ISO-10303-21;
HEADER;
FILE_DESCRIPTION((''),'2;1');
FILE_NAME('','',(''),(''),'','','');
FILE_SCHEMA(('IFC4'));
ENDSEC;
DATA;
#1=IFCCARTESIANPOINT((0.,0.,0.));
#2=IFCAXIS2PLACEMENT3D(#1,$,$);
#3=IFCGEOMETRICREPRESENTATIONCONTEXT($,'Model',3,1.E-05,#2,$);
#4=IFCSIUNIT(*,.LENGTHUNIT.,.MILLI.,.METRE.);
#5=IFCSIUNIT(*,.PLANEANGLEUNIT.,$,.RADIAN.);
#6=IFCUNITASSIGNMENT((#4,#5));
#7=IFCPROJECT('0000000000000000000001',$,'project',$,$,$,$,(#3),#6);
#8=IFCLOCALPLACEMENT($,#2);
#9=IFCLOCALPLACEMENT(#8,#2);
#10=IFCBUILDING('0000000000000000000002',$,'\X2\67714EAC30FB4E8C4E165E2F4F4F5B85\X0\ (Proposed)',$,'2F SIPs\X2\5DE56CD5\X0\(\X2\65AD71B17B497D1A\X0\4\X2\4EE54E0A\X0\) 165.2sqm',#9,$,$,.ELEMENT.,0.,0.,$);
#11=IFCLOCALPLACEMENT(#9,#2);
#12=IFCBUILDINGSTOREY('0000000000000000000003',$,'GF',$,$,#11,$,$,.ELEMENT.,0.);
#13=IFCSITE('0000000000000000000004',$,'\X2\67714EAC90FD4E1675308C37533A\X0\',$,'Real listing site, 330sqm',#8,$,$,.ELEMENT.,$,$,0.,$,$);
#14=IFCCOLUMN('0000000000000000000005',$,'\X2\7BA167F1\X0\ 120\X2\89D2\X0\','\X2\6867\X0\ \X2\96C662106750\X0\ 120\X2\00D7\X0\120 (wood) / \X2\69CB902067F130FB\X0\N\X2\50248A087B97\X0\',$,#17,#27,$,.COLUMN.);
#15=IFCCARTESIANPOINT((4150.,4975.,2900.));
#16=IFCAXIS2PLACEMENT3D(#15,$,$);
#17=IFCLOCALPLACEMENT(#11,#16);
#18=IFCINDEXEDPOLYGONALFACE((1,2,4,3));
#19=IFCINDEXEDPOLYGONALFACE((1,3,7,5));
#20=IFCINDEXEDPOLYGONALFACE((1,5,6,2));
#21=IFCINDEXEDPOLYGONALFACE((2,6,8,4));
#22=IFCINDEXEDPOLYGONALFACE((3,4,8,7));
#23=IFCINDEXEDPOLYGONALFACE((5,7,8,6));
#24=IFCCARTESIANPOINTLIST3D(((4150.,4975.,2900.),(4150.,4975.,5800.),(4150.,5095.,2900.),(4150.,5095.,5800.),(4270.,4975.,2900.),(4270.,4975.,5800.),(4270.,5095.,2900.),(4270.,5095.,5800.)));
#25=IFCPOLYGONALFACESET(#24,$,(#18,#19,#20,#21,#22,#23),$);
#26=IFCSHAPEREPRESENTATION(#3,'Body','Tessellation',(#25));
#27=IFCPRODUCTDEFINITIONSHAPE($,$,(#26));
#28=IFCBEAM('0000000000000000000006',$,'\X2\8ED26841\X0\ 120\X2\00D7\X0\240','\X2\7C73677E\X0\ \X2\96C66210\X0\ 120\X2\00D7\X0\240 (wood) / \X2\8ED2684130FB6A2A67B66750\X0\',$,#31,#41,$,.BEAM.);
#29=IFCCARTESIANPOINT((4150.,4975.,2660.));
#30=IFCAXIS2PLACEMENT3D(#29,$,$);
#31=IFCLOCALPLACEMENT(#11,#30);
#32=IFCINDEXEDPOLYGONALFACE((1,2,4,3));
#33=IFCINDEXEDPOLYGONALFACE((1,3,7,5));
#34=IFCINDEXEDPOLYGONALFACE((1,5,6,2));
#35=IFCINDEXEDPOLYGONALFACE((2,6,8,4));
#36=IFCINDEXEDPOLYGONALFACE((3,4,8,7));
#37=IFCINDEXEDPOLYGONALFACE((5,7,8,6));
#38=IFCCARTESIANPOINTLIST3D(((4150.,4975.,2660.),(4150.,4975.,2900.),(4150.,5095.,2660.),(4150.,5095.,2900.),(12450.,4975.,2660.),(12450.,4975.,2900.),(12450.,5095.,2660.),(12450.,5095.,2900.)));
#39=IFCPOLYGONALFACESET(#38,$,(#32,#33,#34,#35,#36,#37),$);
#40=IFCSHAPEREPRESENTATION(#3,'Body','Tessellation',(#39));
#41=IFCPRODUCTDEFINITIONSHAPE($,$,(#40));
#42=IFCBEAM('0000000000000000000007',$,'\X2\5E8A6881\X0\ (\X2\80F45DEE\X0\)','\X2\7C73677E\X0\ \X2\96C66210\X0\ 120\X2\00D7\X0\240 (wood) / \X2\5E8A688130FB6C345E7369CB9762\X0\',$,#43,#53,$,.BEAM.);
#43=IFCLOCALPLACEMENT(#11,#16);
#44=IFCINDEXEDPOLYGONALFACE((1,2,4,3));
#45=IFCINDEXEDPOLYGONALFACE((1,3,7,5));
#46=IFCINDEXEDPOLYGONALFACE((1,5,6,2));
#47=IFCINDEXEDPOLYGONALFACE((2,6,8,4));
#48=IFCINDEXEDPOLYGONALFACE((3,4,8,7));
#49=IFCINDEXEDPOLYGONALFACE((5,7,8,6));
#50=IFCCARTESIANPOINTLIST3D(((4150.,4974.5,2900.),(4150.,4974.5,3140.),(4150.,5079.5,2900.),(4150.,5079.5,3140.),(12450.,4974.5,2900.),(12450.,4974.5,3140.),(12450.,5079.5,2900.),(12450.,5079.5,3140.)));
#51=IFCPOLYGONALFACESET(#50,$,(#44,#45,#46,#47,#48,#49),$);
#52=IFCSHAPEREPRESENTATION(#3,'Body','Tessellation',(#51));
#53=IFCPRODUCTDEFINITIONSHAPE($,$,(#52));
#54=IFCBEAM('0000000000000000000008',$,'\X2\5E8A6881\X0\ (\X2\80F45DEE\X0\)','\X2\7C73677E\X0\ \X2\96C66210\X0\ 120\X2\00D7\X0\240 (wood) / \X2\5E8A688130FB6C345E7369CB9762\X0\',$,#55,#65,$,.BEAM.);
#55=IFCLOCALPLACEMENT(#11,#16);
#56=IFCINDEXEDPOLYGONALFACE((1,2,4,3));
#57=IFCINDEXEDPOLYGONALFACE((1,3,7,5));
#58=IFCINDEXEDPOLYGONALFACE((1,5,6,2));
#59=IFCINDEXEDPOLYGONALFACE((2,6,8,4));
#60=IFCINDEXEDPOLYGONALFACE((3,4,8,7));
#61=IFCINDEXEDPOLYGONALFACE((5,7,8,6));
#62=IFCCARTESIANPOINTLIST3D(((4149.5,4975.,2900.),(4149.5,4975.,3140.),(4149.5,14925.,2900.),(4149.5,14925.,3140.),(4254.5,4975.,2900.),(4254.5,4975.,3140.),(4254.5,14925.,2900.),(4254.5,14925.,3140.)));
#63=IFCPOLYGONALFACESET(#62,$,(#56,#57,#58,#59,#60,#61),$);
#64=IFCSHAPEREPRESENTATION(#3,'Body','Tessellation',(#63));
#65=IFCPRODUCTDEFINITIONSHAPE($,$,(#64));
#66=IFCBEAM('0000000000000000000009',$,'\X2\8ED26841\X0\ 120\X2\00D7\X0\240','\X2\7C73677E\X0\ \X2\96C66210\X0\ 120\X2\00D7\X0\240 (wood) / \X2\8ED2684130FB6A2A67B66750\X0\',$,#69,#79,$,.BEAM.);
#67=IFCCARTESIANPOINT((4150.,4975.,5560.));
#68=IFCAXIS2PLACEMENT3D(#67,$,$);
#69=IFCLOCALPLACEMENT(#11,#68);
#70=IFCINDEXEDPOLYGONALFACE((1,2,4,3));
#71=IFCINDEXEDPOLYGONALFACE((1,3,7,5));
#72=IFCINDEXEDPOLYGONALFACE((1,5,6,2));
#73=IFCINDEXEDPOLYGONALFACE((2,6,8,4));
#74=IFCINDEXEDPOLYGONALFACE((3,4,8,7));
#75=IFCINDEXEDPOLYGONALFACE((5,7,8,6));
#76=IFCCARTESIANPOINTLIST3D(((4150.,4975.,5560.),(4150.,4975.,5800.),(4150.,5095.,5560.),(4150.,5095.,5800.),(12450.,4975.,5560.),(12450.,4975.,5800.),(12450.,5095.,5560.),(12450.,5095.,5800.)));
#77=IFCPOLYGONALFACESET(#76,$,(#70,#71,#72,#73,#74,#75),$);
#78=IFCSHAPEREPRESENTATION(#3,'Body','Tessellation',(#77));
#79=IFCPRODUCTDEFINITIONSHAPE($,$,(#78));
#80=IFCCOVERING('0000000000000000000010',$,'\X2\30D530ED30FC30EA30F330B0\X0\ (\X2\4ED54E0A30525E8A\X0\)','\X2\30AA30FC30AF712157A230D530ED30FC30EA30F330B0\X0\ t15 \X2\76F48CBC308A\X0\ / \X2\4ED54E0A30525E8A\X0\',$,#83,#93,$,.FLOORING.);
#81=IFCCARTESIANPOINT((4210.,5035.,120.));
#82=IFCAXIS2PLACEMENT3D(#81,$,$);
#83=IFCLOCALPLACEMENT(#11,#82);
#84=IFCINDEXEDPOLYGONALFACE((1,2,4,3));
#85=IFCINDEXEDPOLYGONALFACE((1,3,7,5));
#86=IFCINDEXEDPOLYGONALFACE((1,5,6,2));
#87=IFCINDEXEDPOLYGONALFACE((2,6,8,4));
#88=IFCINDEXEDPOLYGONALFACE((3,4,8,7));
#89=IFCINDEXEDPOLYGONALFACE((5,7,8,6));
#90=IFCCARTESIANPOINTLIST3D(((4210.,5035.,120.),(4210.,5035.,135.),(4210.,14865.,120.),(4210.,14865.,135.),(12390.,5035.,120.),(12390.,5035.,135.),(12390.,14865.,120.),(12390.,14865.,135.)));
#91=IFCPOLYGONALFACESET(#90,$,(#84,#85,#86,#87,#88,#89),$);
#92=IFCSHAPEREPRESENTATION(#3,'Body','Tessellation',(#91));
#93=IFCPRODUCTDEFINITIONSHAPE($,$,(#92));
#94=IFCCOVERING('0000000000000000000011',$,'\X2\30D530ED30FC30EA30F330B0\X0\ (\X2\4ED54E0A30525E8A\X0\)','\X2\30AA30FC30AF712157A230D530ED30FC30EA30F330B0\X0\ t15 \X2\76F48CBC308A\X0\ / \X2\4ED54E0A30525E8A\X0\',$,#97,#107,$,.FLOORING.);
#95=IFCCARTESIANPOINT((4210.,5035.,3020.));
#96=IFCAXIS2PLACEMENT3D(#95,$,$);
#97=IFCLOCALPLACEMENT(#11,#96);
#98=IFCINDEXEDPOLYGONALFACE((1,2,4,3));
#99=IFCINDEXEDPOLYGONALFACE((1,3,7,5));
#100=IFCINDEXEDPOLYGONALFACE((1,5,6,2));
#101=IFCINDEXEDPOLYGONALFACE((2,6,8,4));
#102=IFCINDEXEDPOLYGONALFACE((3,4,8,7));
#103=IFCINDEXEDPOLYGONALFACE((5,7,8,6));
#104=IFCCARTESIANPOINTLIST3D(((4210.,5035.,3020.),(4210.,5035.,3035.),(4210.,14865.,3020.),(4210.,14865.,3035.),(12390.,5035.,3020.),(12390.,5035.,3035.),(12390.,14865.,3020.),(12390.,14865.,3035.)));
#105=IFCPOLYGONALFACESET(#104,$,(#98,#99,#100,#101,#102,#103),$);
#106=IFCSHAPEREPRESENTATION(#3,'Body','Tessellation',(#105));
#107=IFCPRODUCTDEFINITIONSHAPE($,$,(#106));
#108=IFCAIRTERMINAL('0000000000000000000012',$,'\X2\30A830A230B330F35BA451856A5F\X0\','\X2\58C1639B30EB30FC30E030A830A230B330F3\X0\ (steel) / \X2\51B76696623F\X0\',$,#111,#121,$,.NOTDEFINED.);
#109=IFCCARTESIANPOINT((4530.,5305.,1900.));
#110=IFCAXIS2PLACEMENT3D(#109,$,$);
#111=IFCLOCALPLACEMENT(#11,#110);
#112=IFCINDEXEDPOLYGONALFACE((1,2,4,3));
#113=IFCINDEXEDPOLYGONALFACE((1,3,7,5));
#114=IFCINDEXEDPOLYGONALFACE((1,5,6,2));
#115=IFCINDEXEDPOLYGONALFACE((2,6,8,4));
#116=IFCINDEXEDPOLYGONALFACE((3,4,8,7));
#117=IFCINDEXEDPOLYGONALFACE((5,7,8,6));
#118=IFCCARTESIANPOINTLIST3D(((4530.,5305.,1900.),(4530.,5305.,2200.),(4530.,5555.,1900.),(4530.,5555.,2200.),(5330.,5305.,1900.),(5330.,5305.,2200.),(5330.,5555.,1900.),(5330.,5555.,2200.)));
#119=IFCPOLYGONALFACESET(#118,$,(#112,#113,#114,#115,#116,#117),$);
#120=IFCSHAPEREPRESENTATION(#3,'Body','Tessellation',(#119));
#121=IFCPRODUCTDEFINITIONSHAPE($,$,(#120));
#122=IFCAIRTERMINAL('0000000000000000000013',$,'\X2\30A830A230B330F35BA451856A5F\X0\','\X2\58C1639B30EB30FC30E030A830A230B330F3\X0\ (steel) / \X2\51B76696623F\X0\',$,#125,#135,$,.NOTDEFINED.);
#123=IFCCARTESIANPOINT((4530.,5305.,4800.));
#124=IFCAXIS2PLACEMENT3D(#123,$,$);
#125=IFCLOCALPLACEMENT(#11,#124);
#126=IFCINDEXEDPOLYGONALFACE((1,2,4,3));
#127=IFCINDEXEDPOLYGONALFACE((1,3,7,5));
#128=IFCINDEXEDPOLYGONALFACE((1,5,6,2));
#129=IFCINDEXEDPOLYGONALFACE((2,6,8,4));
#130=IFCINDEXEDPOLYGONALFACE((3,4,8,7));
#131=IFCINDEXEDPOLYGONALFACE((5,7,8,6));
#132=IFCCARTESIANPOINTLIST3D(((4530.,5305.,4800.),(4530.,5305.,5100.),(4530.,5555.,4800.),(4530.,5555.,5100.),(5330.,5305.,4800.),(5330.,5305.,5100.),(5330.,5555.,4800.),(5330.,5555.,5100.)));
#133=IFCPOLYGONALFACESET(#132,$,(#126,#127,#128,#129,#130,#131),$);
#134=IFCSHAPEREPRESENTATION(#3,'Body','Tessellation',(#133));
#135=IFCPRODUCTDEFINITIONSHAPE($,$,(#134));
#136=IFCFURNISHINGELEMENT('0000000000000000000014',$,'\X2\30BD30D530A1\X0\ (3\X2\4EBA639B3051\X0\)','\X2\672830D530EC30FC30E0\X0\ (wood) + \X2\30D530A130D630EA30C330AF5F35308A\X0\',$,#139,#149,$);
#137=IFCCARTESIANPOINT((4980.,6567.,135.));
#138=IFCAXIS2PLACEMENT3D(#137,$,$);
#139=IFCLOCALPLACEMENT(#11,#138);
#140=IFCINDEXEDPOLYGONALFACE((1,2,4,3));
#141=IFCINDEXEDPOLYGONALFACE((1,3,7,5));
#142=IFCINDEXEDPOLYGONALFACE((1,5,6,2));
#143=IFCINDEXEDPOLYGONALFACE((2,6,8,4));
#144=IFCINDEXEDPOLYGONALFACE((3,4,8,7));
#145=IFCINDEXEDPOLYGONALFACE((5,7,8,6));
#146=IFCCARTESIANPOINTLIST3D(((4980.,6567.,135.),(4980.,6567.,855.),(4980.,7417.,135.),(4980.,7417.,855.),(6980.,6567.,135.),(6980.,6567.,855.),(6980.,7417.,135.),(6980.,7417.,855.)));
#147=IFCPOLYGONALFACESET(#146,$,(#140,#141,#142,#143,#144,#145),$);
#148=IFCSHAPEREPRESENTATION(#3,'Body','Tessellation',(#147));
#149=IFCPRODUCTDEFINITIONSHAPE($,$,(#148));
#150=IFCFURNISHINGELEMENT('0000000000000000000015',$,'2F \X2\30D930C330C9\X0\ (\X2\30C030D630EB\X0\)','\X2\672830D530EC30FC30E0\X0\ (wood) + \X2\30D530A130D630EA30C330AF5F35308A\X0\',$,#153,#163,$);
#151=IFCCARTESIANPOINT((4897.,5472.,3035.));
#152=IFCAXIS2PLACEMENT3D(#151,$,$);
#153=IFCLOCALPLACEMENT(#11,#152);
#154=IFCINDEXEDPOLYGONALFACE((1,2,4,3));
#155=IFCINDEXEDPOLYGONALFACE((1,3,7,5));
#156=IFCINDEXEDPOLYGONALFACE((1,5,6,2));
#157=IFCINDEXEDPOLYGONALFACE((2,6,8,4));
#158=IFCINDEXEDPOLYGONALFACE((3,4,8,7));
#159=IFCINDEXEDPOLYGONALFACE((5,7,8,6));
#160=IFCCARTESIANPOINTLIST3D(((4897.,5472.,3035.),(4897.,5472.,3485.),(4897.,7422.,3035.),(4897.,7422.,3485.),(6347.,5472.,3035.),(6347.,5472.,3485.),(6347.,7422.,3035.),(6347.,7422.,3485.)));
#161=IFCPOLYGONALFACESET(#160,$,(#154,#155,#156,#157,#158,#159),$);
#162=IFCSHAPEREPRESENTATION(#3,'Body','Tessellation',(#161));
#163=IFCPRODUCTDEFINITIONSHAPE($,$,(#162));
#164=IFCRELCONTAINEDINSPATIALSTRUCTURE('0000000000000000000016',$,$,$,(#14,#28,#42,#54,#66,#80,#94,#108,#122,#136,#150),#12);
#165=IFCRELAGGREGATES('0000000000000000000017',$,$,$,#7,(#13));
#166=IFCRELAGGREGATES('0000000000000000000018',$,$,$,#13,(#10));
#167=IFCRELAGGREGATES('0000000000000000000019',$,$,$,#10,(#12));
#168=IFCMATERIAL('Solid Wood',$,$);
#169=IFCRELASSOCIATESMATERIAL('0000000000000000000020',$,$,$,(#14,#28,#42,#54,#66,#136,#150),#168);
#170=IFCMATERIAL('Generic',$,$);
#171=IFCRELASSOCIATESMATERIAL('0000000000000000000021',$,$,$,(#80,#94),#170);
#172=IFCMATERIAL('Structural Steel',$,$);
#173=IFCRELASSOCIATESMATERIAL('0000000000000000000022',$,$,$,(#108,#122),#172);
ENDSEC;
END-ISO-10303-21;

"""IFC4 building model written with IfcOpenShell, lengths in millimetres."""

from ifc_helpers import new_model, si_unit, frame, frame_2d, origin, place, context, project, spatial, rectangle, extrude, material, element, save


model = new_model("IFC4")

# Units and contexts
model_context = context("Model", 3, precision=1e-05, world=origin())
ifc_project = project(units=[si_unit("LENGTHUNIT", "METRE", prefix="MILLI"), si_unit("PLANEANGLEUNIT", "RADIAN")], contexts=[model_context])

# Site, building, storey
site_placement = place(None, origin())
site = spatial("IfcSite", under=ifc_project, at=site_placement, Name="東京都世田谷区", ObjectType="Real listing site, 330sqm", CompositionType="ELEMENT", RefElevation=0.0)
building_placement = place(site_placement, origin())
building = spatial("IfcBuilding", under=site, at=building_placement, Name="東京・二世帯住宅 (Proposed)", ObjectType="2F SIPs工法(断熱等級4以上) 165.2sqm", CompositionType="ELEMENT", ElevationOfRefHeight=0.0, ElevationOfTerrain=0.0)
storey_placement = place(building_placement, origin())
storey = spatial("IfcBuildingStorey", under=building, at=storey_placement, Name="GF", CompositionType="ELEMENT", Elevation=0.0)

# Column
ifc_material_1 = material(Name="Solid Wood")
column_1_placement = place(storey_placement, frame((4150.0, 4975.0, 2900.0)))
element("IfcColumn", 1, at=column_1_placement, inside=storey, material=ifc_material_1, Name="管柱 120角", Description="桧 集成材 120×120 (wood) / 構造柱・N値計算", PredefinedType="COLUMN", context=model_context, shape_type="SweptSolid", body=[
    extrude(rectangle(XDim=120.0, YDim=120.0, at=frame_2d((60.0, 60.0))), frame((4150.0, 4975.0, 2900.0)), (0.0, 0.0, 1.0), 2900.0),
])

# Beams
beam_1_placement = place(storey_placement, frame((4150.0, 4975.0, 2660.0)))
element("IfcBeam", 2, at=beam_1_placement, inside=storey, material=ifc_material_1, Name="軒桁 120×240", Description="米松 集成 120×240 (wood) / 軒桁・横架材", PredefinedType="BEAM", context=model_context, shape_type="SweptSolid", body=[
    extrude(rectangle(XDim=8300.0, YDim=120.0, at=frame_2d((4150.0, 60.0))), frame((4150.0, 4975.0, 2660.0)), (0.0, 0.0, 1.0), 240.0),
])
beam_2_placement = place(storey_placement, frame((4150.0, 4975.0, 2900.0)))
element("IfcBeam", 3, at=beam_2_placement, inside=storey, material=ifc_material_1, Name="床梁 (胴差)", Description="米松 集成 120×240 (wood) / 床梁・水平構面", PredefinedType="BEAM", context=model_context, shape_type="SweptSolid", body=[
    extrude(rectangle(XDim=8300.0, YDim=105.0, at=frame_2d((4150.0, 52.0))), frame((4150.0, 4975.0, 2900.0)), (0.0, 0.0, 1.0), 240.0),
])
beam_3_placement = place(storey_placement, frame((4150.0, 4975.0, 2900.0)))
element("IfcBeam", 4, at=beam_3_placement, inside=storey, material=ifc_material_1, Name="床梁 (胴差)", Description="米松 集成 120×240 (wood) / 床梁・水平構面", PredefinedType="BEAM", context=model_context, shape_type="SweptSolid", body=[
    extrude(rectangle(XDim=105.0, YDim=9950.0, at=frame_2d((52.0, 4975.0))), frame((4150.0, 4975.0, 2900.0)), (0.0, 0.0, 1.0), 240.0),
])
beam_4_placement = place(storey_placement, frame((4150.0, 4975.0, 5560.0)))
element("IfcBeam", 5, at=beam_4_placement, inside=storey, material=ifc_material_1, Name="軒桁 120×240", Description="米松 集成 120×240 (wood) / 軒桁・横架材", PredefinedType="BEAM", context=model_context, shape_type="SweptSolid", body=[
    extrude(rectangle(XDim=8300.0, YDim=120.0, at=frame_2d((4150.0, 60.0))), frame((4150.0, 4975.0, 5560.0)), (0.0, 0.0, 1.0), 240.0),
])

# Coverings
ifc_material_2 = material(Name="Generic")
covering_1_placement = place(storey_placement, frame((4210.0, 5035.0, 120.0)))
element("IfcCovering", 6, at=covering_1_placement, inside=storey, material=ifc_material_2, Name="フローリング (仕上げ床)", Description="オーク無垢フローリング t15 直貼り / 仕上げ床", PredefinedType="FLOORING", context=model_context, shape_type="SweptSolid", body=[
    extrude(rectangle(XDim=8180.0, YDim=9830.0, at=frame_2d((4090.0, 4915.0))), frame((4210.0, 5035.0, 120.0)), (0.0, 0.0, 1.0), 15.0),
])
covering_2_placement = place(storey_placement, frame((4210.0, 5035.0, 3020.0)))
element("IfcCovering", 7, at=covering_2_placement, inside=storey, material=ifc_material_2, Name="フローリング (仕上げ床)", Description="オーク無垢フローリング t15 直貼り / 仕上げ床", PredefinedType="FLOORING", context=model_context, shape_type="SweptSolid", body=[
    extrude(rectangle(XDim=8180.0, YDim=9830.0, at=frame_2d((4090.0, 4915.0))), frame((4210.0, 5035.0, 3020.0)), (0.0, 0.0, 1.0), 15.0),
])

# Air terminals
ifc_material_3 = material(Name="Structural Steel")
air_terminal_1_placement = place(storey_placement, frame((4530.0, 5305.0, 1900.0)))
element("IfcAirTerminal", 8, at=air_terminal_1_placement, inside=storey, material=ifc_material_3, Name="エアコン室内機", Description="壁掛ルームエアコン (steel) / 冷暖房", PredefinedType="NOTDEFINED", context=model_context, shape_type="SweptSolid", body=[
    extrude(rectangle(XDim=800.0, YDim=250.0, at=frame_2d((400.0, 125.0))), frame((4530.0, 5305.0, 1900.0)), (0.0, 0.0, 1.0), 300.0),
])
air_terminal_2_placement = place(storey_placement, frame((4530.0, 5305.0, 4800.0)))
element("IfcAirTerminal", 9, at=air_terminal_2_placement, inside=storey, material=ifc_material_3, Name="エアコン室内機", Description="壁掛ルームエアコン (steel) / 冷暖房", PredefinedType="NOTDEFINED", context=model_context, shape_type="SweptSolid", body=[
    extrude(rectangle(XDim=800.0, YDim=250.0, at=frame_2d((400.0, 125.0))), frame((4530.0, 5305.0, 4800.0)), (0.0, 0.0, 1.0), 300.0),
])

# Furnishing elements
furnishing_1_placement = place(storey_placement, frame((4980.0, 6567.0, 135.0)))
element("IfcFurnishingElement", 10, at=furnishing_1_placement, inside=storey, material=ifc_material_1, Name="ソファ (3人掛け)", Description="木フレーム (wood) + ファブリック張り", context=model_context, shape_type="SweptSolid", body=[
    extrude(rectangle(XDim=2000.0, YDim=850.0, at=frame_2d((1000.0, 425.0))), frame((4980.0, 6567.0, 135.0)), (0.0, 0.0, 1.0), 720.0),
])
furnishing_2_placement = place(storey_placement, frame((4897.0, 5472.0, 3035.0)))
element("IfcFurnishingElement", 11, at=furnishing_2_placement, inside=storey, material=ifc_material_1, Name="2F ベッド (ダブル)", Description="木フレーム (wood) + ファブリック張り", context=model_context, shape_type="SweptSolid", body=[
    extrude(rectangle(XDim=1450.0, YDim=1950.0, at=frame_2d((725.0, 975.0))), frame((4897.0, 5472.0, 3035.0)), (0.0, 0.0, 1.0), 450.0),
])

save(model, "model.ifc")
